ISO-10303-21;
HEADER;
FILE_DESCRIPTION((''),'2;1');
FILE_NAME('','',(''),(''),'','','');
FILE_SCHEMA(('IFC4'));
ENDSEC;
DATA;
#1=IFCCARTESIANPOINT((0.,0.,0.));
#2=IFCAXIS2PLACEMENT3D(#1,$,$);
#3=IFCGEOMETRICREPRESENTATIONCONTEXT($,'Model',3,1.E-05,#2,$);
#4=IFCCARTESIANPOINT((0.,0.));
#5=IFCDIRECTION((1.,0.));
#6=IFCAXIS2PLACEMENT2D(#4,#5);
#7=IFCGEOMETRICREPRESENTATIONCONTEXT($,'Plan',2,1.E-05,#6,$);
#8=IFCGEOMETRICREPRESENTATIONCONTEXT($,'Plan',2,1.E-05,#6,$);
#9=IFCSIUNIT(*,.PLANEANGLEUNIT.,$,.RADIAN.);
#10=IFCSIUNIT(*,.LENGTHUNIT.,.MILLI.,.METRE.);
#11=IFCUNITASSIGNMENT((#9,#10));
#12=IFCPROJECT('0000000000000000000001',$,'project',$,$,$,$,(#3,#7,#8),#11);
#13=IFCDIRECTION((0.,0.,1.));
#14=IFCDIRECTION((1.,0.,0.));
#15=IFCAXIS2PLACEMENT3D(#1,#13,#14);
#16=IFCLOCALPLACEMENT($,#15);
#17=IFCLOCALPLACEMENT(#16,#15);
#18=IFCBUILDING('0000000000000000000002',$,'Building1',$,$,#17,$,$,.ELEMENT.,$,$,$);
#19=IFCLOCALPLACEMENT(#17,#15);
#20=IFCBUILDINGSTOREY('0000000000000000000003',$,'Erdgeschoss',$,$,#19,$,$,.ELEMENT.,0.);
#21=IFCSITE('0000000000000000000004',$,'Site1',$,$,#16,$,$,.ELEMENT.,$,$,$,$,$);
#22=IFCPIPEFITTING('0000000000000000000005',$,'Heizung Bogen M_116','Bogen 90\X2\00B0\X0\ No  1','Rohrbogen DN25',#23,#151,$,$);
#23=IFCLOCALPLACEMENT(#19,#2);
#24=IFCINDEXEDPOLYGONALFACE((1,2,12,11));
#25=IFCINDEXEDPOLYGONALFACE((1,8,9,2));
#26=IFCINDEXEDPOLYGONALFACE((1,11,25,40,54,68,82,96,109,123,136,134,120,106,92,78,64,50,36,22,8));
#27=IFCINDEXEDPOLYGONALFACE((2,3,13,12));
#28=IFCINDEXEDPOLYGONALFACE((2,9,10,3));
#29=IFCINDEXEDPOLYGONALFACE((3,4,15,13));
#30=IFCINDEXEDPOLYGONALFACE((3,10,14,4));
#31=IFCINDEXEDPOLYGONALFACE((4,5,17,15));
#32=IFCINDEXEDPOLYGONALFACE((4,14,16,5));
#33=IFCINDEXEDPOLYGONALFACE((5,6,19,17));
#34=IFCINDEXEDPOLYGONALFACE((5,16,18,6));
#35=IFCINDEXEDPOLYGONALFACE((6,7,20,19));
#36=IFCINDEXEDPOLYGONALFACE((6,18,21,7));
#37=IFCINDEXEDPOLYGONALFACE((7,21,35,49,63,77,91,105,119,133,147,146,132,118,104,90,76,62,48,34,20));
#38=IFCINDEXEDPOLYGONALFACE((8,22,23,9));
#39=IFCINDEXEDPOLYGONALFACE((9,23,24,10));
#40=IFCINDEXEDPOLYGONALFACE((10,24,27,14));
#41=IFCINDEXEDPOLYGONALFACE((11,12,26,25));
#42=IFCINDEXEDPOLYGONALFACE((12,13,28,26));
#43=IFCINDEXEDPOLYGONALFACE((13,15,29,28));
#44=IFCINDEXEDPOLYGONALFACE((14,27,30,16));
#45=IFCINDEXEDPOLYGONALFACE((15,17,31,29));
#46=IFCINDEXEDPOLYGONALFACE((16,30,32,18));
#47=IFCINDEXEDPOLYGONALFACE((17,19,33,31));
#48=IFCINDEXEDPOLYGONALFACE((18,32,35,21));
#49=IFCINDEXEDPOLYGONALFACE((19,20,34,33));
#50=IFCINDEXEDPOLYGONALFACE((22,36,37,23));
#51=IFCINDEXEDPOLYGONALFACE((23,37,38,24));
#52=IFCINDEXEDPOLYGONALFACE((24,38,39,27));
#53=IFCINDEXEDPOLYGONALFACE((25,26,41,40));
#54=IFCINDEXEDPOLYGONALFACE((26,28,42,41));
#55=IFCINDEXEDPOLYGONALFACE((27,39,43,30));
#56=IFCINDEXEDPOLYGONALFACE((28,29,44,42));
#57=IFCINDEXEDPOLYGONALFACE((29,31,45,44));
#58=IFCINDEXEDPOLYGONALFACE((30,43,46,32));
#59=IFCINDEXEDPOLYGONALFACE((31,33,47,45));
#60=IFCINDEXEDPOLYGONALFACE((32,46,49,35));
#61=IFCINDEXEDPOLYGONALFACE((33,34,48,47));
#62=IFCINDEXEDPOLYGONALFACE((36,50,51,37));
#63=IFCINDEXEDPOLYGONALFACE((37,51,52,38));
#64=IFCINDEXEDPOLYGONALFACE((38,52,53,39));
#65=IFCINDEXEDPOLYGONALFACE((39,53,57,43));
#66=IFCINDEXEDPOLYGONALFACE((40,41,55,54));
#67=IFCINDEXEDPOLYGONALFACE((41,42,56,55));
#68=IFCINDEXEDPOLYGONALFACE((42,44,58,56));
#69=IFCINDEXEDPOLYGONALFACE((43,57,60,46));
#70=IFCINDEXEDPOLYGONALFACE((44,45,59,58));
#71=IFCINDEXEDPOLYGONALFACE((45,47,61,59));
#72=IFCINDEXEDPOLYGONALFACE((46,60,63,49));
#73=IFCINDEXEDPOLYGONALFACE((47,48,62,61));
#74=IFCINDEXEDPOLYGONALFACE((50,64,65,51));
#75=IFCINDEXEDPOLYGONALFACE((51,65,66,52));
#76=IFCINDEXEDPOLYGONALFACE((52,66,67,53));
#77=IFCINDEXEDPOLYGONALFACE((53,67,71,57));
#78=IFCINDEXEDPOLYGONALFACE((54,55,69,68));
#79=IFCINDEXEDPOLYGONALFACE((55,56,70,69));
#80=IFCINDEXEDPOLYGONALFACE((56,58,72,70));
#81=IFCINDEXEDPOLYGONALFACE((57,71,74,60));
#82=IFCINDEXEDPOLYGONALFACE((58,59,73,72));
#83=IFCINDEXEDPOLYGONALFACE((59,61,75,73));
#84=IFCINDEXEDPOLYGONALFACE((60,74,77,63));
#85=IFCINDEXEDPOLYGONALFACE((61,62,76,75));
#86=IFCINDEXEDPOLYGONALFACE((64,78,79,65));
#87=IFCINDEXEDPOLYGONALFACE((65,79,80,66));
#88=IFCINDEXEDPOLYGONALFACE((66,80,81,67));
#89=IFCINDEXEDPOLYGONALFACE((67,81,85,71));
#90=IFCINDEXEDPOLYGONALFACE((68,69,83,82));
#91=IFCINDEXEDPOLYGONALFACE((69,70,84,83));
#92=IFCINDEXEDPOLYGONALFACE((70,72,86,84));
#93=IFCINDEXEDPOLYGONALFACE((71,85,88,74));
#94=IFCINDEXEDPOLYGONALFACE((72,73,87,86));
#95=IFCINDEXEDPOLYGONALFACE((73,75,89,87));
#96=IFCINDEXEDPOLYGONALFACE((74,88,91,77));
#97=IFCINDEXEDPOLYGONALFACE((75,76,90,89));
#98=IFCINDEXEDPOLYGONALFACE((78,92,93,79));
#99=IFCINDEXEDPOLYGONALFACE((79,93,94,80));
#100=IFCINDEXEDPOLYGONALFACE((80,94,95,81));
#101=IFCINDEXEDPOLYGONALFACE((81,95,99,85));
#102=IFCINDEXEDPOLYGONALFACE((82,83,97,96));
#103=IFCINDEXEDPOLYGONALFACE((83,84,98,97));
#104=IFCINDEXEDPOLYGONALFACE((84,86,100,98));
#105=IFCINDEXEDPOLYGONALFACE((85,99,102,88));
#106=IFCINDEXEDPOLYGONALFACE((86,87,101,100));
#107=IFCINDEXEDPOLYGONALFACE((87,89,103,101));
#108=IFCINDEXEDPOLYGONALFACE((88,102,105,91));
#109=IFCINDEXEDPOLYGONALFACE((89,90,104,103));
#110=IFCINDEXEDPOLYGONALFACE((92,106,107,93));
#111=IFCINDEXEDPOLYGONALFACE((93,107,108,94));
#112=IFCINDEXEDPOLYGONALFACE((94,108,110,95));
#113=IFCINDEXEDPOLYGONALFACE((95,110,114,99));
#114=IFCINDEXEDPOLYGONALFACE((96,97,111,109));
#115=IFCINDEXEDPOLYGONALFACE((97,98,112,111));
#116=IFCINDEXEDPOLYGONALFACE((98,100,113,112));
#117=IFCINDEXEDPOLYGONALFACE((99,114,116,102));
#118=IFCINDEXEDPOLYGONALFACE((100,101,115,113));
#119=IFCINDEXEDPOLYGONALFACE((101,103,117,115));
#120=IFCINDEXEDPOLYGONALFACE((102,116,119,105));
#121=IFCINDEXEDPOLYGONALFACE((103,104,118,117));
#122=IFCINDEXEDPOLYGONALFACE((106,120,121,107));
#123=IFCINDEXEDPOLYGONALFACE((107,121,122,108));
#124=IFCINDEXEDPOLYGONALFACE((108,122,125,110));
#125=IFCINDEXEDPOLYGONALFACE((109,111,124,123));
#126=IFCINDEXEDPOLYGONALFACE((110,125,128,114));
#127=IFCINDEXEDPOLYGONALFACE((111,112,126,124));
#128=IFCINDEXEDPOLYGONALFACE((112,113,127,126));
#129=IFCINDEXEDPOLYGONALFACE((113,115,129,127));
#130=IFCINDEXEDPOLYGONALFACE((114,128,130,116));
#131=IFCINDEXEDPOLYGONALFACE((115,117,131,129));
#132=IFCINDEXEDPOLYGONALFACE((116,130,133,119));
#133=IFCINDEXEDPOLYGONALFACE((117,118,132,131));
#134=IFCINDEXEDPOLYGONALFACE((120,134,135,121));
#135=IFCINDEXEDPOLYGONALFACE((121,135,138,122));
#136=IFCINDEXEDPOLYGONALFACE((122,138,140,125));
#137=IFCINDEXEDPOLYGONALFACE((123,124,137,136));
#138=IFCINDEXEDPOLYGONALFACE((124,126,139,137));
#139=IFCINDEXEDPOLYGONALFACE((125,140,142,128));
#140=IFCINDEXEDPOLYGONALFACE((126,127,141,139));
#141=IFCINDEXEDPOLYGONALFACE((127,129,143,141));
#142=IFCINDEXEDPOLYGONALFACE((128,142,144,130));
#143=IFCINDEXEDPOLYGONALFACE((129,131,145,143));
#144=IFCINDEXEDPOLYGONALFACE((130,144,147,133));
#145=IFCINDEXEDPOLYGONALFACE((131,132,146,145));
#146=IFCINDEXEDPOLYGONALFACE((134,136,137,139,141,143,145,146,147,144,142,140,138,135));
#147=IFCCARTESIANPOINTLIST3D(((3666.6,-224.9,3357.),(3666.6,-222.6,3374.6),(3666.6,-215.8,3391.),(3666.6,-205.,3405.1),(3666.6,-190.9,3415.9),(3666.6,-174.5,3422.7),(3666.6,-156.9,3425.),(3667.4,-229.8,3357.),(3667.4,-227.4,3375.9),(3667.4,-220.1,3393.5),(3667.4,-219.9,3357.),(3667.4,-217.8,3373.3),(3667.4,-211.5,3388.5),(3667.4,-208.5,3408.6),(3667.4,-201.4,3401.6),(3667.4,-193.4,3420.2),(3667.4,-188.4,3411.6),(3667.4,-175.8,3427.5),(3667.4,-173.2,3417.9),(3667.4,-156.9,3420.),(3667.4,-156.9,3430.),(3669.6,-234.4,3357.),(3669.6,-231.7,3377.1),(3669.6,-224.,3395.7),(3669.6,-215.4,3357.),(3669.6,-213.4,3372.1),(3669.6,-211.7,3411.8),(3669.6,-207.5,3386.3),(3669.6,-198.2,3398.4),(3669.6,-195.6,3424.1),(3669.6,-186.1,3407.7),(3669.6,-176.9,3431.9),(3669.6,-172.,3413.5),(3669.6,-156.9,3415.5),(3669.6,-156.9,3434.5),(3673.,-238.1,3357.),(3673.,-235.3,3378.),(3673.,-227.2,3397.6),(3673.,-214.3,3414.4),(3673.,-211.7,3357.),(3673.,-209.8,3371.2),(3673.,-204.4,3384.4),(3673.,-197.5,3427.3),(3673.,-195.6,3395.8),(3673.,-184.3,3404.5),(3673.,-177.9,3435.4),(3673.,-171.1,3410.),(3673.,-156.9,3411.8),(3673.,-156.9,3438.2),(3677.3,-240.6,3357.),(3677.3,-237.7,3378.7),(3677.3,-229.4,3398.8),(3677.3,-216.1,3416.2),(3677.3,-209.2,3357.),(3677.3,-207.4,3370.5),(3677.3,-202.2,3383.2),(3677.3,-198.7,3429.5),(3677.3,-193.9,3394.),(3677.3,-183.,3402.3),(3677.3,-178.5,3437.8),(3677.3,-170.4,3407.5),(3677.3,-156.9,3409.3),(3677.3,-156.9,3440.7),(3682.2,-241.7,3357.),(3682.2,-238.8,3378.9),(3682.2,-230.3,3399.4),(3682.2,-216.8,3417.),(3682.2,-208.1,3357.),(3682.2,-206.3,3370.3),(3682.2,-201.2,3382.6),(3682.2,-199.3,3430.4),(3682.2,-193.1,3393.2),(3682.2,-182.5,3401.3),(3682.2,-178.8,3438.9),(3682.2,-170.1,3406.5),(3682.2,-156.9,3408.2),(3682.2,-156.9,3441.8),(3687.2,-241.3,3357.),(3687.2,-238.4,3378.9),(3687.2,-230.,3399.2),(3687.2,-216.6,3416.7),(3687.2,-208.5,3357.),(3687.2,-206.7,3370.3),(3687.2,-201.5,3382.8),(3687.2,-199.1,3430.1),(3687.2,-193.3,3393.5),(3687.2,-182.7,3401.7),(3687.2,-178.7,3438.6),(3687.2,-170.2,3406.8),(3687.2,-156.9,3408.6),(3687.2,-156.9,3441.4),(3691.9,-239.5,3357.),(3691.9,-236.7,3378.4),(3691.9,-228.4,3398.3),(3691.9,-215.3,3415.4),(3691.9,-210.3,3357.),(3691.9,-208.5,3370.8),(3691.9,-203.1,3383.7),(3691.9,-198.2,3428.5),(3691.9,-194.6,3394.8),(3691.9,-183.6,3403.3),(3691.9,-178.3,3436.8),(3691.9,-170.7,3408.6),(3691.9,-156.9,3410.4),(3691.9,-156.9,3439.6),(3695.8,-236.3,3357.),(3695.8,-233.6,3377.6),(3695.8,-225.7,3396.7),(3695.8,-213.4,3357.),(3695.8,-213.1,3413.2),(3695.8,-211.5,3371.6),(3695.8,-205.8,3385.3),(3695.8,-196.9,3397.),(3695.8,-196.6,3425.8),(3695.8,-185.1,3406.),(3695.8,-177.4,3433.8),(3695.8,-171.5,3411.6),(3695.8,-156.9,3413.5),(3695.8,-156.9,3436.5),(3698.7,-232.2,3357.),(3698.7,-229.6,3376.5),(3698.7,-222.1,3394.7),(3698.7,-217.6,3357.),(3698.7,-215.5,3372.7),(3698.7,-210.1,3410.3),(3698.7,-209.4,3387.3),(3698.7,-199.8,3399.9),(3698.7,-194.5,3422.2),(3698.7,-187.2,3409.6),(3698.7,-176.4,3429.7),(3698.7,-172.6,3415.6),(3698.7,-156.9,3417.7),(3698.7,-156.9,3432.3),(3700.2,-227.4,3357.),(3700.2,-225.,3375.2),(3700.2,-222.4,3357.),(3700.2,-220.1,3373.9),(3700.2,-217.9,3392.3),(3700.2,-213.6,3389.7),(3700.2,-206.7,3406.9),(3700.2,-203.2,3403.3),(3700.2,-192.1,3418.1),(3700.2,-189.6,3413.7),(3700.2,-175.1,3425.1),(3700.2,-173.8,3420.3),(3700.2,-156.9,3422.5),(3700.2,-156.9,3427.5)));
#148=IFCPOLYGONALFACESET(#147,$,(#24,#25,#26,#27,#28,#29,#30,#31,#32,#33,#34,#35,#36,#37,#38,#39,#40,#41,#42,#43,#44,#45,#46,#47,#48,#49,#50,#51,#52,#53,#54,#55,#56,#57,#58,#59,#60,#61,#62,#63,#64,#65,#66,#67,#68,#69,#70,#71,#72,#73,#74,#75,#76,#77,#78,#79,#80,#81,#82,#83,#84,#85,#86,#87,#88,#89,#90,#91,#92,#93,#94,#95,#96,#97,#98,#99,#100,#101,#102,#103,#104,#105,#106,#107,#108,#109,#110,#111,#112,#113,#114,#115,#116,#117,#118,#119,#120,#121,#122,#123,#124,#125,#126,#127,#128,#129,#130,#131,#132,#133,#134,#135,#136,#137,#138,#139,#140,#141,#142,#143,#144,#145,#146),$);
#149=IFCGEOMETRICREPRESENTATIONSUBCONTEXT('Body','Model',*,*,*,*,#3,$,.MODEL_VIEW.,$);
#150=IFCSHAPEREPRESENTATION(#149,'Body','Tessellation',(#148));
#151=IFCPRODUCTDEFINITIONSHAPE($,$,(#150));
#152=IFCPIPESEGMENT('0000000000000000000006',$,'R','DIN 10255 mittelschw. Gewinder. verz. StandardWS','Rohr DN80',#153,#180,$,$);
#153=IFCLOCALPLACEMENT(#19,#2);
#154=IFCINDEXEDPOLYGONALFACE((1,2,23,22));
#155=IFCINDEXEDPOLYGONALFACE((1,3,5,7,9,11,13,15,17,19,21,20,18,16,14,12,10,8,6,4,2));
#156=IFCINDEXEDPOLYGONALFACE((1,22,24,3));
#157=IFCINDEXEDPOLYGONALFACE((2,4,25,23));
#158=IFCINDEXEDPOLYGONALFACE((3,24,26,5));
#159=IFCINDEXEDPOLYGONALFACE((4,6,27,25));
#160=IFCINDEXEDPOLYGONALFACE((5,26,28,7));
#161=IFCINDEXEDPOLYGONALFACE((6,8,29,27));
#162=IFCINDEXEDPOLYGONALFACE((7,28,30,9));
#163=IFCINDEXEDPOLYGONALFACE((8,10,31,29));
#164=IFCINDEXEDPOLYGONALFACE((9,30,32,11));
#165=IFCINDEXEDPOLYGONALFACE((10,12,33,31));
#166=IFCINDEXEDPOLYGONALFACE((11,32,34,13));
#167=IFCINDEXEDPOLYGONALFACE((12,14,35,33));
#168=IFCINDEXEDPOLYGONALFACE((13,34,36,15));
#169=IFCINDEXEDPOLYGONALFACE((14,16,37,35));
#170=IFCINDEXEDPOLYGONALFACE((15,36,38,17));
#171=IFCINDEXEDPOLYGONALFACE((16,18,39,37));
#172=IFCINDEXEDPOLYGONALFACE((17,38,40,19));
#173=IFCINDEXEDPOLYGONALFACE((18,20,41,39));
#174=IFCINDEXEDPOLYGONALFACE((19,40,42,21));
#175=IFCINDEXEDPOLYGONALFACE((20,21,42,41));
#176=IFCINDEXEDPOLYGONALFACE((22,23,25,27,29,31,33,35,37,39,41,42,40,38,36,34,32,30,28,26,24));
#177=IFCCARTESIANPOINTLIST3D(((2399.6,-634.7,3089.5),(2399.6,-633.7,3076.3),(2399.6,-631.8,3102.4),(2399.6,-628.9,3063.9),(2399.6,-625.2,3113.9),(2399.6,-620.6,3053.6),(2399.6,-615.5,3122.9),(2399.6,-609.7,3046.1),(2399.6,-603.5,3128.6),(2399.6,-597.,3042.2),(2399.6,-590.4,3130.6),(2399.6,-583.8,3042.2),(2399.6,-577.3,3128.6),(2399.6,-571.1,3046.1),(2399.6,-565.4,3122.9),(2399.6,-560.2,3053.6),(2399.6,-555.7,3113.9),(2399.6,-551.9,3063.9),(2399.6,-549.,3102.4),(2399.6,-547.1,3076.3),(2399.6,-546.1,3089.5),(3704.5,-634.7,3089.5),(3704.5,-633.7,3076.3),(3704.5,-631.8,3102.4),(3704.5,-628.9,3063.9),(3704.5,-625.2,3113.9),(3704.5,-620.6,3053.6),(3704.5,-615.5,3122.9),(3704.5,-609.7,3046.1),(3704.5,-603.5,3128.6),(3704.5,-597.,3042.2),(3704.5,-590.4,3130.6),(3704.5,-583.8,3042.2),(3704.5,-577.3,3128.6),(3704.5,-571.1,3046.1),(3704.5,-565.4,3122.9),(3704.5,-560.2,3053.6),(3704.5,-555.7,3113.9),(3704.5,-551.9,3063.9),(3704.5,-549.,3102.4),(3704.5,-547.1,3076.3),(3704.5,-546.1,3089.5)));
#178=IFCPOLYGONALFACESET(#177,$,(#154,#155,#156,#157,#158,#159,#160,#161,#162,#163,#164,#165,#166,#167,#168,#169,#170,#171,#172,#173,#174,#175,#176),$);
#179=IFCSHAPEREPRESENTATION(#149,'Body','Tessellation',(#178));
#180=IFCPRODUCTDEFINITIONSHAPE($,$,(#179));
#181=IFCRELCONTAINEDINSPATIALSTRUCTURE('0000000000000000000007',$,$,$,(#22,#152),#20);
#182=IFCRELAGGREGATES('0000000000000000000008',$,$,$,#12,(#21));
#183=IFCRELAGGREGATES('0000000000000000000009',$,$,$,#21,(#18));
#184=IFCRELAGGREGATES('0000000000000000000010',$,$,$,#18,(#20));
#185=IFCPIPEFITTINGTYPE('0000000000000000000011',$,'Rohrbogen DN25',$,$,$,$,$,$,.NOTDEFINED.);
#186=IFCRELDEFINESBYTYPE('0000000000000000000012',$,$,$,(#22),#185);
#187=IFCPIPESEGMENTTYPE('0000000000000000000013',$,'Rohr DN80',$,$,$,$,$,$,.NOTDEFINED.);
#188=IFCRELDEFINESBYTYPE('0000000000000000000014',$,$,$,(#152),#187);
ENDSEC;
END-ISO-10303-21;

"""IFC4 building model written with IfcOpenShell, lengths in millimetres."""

from ifc_helpers import new_model, entity, si_unit, frame, origin, origin_with_axes, origin_2d_with_axis, place, context, subcontext, project, spatial, circle, extrude, source, transform, mapped, type_object, element, save


model = new_model("IFC4")

# Units and contexts
model_context = context("Model", 3, precision=1e-05, world=origin())
plan_context_1 = context("Plan", 2, precision=1e-05, world=origin_2d_with_axis())
plan_context_2 = context("Plan", 2, precision=1e-05, world=origin_2d_with_axis())
body_context = subcontext(model_context, "Body", "Model", "MODEL_VIEW")
ifc_project = project(units=[si_unit("PLANEANGLEUNIT", "RADIAN"), si_unit("LENGTHUNIT", "METRE", prefix="MILLI")], contexts=[model_context, plan_context_1, plan_context_2])

# Site, building, storey
site_placement = place(None, origin_with_axes())
site = spatial("IfcSite", under=ifc_project, at=site_placement, Name="Site1", CompositionType="ELEMENT")
building_placement = place(site_placement, origin_with_axes())
building = spatial("IfcBuilding", under=site, at=building_placement, Name="Building1", CompositionType="ELEMENT")
storey_placement = place(building_placement, origin_with_axes())
storey = spatial("IfcBuildingStorey", under=building, at=storey_placement, Name="Erdgeschoss", CompositionType="ELEMENT", Elevation=0.0)

# Pipe fitting
pipe_fitting_type_1 = type_object("IfcPipeFittingType", Name="Rohrbogen DN25", PredefinedType="NOTDEFINED")
shared_shape_1 = source(origin_with_axes(), body_context, "Body", "SolidModel", [
    entity("IfcRevolvedAreaSolid", entity("IfcCircleProfileDef", "AREA", None, entity("IfcAxis2Placement2D", entity("IfcCartesianPoint", [0.0, 0.0]), entity("IfcDirection", [1.0, 0.0])), 16.9), entity("IfcAxis2Placement3D", entity("IfcCartesianPoint", [-42.4, 0.0, 25.6]), entity("IfcDirection", [1.0, 0.0, 0.0]), entity("IfcDirection", [0.0, -1.0, 0.0])), entity("IfcAxis1Placement", entity("IfcCartesianPoint", [0.0, 68.0, 0.0]), entity("IfcDirection", [-1.0, 0.0, 0.0])), 1.570796),
])
pipe_fitting_1_placement = place(storey_placement, frame((3683.5, -199.3, 3399.4), z_axis=(0.0, 0.0, 1.0), x_axis=(1.0, 0.0, 0.0)))
element("IfcPipeFitting", 1, at=pipe_fitting_1_placement, inside=storey, type_object=pipe_fitting_type_1, Name="Heizung Bogen M_116", Description="Bogen 90° No  1", ObjectType="Rohrbogen DN25", context=body_context, shape_type="MappedRepresentation", body=[
    mapped(shared_shape_1, transform((0.0, 0.0, 0.0), x_axis=(0.0, -1.0, 0.0), y_axis=(1.0, 0.0, 0.0), z_axis=(0.0, 0.0, 1.0), scale=1.0)),
])

# Pipe segment
pipe_segment_type_1 = type_object("IfcPipeSegmentType", Name="Rohr DN80", PredefinedType="NOTDEFINED")
pipe_segment_1_placement = place(storey_placement, frame((3052.0, -590.3, 3086.1), z_axis=(0.0, 0.0, 1.0), x_axis=(1.0, 0.0, 0.0)))
element("IfcPipeSegment", 2, at=pipe_segment_1_placement, inside=storey, type_object=pipe_segment_type_1, Name="R", Description="DIN 10255 mittelschw. Gewinder. verz. StandardWS", ObjectType="Rohr DN80", context=body_context, shape_type="SolidModel", body=[
    extrude(circle(Radius=44.5, at=origin_2d_with_axis()), frame((-652.5, -0.2, 0.0), z_axis=(1.0, 0.0, 0.0), x_axis=(0.0, 0.0, 1.0)), (0.0, 0.0, 1.0), 1304.9),
])

save(model, "model.ifc")
